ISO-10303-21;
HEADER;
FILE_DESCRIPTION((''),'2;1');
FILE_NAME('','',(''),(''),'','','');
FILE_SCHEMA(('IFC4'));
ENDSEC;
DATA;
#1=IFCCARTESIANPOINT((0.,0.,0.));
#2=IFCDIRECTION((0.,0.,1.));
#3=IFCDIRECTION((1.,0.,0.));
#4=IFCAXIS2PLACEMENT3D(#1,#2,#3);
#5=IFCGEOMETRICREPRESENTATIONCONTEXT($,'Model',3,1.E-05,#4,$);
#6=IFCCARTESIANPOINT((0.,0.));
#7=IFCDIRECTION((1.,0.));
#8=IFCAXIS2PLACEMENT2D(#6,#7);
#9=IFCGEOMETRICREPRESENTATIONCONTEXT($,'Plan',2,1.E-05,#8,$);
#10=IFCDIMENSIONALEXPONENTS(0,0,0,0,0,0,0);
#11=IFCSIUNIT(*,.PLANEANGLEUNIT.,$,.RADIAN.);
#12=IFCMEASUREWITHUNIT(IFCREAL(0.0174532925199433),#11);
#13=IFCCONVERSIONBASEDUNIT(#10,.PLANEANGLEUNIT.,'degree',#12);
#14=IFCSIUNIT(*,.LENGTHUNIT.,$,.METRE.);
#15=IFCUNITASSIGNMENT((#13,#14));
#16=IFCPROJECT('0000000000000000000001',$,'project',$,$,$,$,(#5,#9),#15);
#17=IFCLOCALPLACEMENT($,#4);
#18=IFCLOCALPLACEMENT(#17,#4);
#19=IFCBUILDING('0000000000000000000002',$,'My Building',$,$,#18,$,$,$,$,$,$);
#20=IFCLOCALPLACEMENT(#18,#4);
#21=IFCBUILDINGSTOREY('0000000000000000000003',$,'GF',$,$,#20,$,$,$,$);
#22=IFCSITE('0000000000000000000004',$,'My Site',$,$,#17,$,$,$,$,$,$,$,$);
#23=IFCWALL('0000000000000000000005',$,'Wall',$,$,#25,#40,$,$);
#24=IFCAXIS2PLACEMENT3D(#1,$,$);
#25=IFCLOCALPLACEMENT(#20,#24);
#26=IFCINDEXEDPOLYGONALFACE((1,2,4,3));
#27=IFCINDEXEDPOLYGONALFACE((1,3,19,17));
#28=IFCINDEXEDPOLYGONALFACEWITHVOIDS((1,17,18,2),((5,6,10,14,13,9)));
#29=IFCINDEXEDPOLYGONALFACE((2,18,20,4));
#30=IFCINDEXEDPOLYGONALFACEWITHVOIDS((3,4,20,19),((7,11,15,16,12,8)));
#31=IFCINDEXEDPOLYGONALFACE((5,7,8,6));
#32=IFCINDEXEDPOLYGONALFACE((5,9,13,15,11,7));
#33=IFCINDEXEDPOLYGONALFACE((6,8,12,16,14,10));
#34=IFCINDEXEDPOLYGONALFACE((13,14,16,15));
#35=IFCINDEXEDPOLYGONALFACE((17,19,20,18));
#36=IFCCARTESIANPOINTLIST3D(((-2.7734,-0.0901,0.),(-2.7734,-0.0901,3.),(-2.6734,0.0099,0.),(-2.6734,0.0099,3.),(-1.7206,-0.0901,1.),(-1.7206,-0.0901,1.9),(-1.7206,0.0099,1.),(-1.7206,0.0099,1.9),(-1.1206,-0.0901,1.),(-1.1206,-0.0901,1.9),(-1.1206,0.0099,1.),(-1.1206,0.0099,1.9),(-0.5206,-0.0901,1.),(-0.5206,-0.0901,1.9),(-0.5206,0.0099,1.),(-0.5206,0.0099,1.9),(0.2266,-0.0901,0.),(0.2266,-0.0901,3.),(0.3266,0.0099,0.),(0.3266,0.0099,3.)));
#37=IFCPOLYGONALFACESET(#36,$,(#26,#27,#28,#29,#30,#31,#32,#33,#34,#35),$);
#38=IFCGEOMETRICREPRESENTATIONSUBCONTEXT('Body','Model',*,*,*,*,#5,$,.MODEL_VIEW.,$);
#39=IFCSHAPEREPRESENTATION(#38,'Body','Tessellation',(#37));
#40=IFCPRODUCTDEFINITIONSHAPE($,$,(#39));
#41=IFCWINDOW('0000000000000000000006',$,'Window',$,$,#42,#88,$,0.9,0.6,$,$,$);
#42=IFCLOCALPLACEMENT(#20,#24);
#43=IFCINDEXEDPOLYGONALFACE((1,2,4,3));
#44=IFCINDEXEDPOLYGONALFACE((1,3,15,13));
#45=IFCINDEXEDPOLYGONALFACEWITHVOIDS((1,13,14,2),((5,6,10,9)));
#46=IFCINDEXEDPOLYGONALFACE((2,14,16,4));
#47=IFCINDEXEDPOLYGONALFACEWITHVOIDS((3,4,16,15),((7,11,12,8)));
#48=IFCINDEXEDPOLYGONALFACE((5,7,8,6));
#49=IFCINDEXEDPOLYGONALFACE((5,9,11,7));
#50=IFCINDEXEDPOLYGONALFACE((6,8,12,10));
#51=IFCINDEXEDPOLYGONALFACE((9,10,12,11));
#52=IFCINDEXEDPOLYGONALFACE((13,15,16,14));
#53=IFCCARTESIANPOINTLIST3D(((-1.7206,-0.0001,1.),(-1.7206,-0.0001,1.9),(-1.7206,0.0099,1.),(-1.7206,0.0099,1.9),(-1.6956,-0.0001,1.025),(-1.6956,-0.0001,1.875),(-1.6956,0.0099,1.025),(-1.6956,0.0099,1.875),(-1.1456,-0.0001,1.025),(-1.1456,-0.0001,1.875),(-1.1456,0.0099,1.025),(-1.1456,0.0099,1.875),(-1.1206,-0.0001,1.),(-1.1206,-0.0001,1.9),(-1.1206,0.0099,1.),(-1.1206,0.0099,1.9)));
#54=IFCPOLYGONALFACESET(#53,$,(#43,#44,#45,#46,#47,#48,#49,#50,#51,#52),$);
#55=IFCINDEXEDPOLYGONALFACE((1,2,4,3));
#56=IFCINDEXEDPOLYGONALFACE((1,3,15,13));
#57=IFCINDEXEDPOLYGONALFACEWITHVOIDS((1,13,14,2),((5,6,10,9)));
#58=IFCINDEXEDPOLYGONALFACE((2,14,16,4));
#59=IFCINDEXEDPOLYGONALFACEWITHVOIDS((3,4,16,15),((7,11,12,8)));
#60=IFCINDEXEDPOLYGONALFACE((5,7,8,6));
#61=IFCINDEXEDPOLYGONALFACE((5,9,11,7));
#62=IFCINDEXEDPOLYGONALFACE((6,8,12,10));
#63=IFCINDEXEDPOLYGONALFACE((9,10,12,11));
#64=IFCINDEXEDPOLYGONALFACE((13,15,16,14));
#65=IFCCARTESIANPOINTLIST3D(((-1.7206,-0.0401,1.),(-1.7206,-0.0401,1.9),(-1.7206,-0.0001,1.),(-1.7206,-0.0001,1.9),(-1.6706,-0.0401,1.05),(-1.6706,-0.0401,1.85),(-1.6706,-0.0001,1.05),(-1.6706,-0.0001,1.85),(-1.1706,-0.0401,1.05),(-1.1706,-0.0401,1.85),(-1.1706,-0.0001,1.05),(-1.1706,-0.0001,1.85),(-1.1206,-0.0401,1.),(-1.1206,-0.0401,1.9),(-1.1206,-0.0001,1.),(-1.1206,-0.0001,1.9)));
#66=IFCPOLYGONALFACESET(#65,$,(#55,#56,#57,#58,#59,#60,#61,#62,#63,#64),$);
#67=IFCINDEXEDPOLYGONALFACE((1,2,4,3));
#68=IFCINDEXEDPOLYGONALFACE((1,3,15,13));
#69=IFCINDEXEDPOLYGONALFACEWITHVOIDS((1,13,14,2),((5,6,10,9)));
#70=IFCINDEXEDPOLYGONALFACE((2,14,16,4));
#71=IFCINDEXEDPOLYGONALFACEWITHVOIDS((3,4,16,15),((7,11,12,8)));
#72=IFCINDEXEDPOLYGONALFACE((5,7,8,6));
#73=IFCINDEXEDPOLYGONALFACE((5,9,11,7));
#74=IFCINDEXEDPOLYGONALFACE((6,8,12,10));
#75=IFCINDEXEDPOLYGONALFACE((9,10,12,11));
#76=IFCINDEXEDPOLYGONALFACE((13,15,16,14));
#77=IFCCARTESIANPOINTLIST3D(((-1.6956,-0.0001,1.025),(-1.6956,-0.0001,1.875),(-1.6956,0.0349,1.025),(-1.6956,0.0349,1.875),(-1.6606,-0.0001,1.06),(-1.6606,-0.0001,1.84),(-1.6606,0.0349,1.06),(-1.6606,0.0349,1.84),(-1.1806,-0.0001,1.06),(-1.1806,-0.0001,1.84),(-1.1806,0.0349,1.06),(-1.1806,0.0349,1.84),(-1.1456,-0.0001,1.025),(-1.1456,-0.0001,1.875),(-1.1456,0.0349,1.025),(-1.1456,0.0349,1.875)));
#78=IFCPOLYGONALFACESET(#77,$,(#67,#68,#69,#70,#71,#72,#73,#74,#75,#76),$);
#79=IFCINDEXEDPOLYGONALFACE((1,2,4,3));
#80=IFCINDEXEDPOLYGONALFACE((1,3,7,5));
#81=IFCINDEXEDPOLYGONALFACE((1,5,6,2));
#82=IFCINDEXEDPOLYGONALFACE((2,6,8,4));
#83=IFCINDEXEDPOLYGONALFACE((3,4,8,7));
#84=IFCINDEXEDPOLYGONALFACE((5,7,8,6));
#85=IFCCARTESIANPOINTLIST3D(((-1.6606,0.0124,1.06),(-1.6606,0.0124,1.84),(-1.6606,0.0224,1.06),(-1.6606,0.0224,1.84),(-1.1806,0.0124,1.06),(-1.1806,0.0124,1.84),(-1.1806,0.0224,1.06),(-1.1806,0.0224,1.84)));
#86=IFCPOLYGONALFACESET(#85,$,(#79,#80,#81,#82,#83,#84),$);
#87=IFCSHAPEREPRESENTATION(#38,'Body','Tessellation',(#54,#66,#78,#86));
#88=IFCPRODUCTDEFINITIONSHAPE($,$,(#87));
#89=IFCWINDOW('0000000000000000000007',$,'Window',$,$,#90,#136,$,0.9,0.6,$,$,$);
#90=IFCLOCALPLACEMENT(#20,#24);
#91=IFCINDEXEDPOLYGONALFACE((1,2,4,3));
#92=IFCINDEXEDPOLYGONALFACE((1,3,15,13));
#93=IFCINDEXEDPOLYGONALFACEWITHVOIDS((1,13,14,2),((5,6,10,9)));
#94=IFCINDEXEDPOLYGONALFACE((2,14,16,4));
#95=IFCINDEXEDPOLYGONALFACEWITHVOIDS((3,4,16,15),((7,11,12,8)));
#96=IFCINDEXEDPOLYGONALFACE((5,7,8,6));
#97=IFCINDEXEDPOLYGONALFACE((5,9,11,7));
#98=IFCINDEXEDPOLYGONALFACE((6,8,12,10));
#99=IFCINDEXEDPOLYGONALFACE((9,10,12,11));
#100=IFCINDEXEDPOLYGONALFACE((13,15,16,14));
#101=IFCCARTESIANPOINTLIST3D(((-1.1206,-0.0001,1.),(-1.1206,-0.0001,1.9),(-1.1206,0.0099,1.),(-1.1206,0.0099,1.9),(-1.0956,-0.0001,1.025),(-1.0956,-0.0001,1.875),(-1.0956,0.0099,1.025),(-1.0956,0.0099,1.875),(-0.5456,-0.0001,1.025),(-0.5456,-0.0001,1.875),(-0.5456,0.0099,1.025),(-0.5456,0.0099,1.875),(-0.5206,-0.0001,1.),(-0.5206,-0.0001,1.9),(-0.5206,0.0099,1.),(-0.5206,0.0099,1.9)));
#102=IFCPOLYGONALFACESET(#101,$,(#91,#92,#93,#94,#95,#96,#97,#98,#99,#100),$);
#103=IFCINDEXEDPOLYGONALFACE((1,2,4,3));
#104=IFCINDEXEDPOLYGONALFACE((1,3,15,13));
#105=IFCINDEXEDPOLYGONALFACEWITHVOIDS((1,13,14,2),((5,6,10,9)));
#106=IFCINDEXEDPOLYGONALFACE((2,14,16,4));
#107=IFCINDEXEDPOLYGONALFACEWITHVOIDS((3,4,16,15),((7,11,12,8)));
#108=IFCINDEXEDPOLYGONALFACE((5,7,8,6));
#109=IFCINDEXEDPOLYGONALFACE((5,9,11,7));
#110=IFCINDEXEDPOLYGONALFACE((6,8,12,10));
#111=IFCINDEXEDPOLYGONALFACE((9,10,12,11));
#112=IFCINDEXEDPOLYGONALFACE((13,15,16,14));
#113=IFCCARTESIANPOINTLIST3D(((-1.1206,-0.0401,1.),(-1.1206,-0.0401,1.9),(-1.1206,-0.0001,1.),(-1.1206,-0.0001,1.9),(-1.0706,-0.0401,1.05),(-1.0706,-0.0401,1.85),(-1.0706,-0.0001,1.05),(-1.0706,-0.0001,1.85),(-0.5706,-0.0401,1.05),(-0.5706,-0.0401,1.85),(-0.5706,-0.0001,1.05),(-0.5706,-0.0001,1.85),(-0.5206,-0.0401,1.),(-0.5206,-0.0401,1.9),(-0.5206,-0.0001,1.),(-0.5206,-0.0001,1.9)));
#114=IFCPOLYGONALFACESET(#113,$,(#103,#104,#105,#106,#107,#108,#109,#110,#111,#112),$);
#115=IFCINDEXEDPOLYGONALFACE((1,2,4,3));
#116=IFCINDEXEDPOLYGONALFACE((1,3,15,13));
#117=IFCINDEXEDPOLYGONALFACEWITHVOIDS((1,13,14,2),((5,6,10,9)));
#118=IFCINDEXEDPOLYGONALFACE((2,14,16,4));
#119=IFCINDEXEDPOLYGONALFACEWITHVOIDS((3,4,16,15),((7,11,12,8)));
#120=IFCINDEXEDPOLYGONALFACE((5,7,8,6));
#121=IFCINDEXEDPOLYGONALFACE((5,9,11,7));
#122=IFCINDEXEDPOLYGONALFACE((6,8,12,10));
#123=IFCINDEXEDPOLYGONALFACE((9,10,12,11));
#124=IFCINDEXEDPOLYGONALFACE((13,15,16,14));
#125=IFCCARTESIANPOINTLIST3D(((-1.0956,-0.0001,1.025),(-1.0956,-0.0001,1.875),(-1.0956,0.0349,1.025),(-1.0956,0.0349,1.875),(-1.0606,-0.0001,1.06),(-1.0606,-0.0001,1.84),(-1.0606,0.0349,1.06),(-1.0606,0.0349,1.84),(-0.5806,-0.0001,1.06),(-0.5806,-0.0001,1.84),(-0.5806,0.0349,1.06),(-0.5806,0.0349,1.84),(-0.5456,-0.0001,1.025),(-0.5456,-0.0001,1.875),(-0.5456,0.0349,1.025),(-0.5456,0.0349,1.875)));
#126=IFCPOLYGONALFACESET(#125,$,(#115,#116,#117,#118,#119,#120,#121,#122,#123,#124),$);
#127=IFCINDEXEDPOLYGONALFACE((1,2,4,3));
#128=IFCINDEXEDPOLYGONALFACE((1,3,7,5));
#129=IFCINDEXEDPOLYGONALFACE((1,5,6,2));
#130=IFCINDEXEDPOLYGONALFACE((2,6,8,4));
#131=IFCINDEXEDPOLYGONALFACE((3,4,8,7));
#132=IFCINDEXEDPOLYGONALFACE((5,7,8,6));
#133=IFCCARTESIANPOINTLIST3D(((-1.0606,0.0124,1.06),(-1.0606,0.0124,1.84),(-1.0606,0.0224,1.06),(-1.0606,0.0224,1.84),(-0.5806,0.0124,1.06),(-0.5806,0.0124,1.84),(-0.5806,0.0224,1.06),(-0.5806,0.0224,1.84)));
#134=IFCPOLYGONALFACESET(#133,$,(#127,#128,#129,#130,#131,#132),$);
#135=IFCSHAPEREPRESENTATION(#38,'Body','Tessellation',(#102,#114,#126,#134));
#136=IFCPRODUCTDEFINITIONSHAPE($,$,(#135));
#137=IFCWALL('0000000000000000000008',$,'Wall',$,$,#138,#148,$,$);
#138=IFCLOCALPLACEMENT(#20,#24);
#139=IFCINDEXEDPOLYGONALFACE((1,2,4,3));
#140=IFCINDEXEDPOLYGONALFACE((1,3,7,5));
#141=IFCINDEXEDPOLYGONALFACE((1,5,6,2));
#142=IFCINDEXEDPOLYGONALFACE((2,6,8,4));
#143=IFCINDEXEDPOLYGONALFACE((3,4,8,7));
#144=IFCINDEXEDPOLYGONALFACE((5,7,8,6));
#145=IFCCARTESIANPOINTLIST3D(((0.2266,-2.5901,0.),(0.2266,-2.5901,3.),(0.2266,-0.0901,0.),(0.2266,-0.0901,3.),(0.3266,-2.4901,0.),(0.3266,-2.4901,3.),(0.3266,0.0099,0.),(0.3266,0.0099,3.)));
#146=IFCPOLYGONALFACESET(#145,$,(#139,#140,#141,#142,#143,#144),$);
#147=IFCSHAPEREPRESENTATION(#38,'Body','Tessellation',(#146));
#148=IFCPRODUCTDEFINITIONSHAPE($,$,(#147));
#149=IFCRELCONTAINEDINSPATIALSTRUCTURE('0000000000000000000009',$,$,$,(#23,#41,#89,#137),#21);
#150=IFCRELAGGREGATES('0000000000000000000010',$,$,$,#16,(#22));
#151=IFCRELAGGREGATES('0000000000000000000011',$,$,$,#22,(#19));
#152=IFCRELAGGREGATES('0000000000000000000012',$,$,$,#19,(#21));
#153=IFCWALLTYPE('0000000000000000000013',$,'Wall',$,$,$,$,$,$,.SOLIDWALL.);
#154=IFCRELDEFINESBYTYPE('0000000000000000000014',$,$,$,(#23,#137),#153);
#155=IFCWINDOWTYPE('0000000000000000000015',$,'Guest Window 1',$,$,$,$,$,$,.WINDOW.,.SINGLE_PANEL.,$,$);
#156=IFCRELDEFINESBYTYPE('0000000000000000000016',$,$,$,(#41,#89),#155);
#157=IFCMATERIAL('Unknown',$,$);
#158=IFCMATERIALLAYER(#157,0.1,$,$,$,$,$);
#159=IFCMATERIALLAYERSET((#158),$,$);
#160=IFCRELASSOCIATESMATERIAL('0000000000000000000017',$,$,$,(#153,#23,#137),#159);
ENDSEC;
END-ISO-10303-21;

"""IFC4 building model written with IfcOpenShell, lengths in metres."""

from ifc_helpers import new_model, entity, si_unit, converted_unit, frame, origin_with_axes, origin_2d_with_axis, place, context, subcontext, project, spatial, line, indexed_curve, outline, extrude, shape, source, transform, mapped, material, layer, layer_set, layer_usage, type_object, type_shapes, element, fill, save


model = new_model("IFC4")

# Units and contexts
model_context = context("Model", 3, precision=1e-05, world=origin_with_axes())
plan_context = context("Plan", 2, precision=1e-05, world=origin_2d_with_axis())
body_context_1 = subcontext(model_context, "Body", "Model", "MODEL_VIEW")
body_context_2 = subcontext(plan_context, "Body", "Plan", "PLAN_VIEW")
ifc_project = project(units=[converted_unit("PLANEANGLEUNIT", "degree", entity("IfcReal", 0.0174532925199433), si_unit("PLANEANGLEUNIT", "RADIAN"), dimensions=[0, 0, 0, 0, 0, 0, 0]), si_unit("LENGTHUNIT", "METRE")], contexts=[model_context, plan_context])

# Site, building, storey
site_placement = place(None, origin_with_axes())
site = spatial("IfcSite", under=ifc_project, at=site_placement, Name="My Site")
building_placement = place(site_placement, origin_with_axes())
building = spatial("IfcBuilding", under=site, at=building_placement, Name="My Building")
storey_placement = place(building_placement, origin_with_axes())
storey = spatial("IfcBuildingStorey", under=building, at=storey_placement, Name="GF")

# Shared definitions
ifc_material = material(Name="Unknown")

# Shared definitions
ifc_layer_1 = layer(ifc_material, 0.1)
ifc_layer_set_1 = layer_set([ifc_layer_1])
wall_type = type_object("IfcWallType", Name="Wall", PredefinedType="SOLIDWALL", material=ifc_layer_set_1)

# Wall, openings, windows
ifc_layer_usage_1 = layer_usage(ifc_layer_set_1, "AXIS2", "POSITIVE", 0.0)
wall_1_placement = place(storey_placement, frame((-2.7734, -0.0901, 0.0), z_axis=(0.0, 0.0, 1.0), x_axis=(1.0, 0.0, 0.0)))
wall_1 = element("IfcWall", 1, at=wall_1_placement, inside=storey, type_object=wall_type, material=ifc_layer_usage_1, Name="Wall", context=body_context_1, shape_type="SweptSolid", body=[
    extrude(outline(indexed_curve([(0.0, 0.0), (0.1, 0.1), (3.1, 0.1), (3.0, 0.0)], segments=[line(1, 2, 3, 4, 1)])), origin_with_axes(), (0.0, 0.0, 1.0), 3.0),
])
shared_shape_1 = source(origin_with_axes(), body_context_1, "Body", "SweptSolid", [
    extrude(outline(indexed_curve([(0.0, 0.0), (0.6, 0.0), (0.6, 0.9), (0.0, 0.9)], segments=[line(1, 2, 3, 4, 1)])), frame((0.0, -0.6, 0.0), z_axis=(0.0, -1.0, 0.0), x_axis=(1.0, 0.0, 0.0)), (0.0, 0.0, -1.0), 1.2),
])
opening_1_placement = place(wall_1_placement, frame((1.0528, 0.0, 1.0), z_axis=(0.0, 0.0, 1.0), x_axis=(1.0, 0.0, 0.0)))
opening_1 = element("IfcOpeningElement", 2, at=opening_1_placement, cuts=wall_1, PredefinedType="OPENING", context=body_context_1, shape_type="MappedRepresentation", body=[
    mapped(shared_shape_1, transform((0.0, 0.0, 0.0), x_axis=(1.0, 0.0, 0.0), y_axis=(0.0, 1.0, 0.0), z_axis=(0.0, 0.0, 1.0), scale=1.0)),
])
opening_2_placement = place(wall_1_placement, frame((1.6528, 0.0, 1.0), z_axis=(0.0, 0.0, 1.0), x_axis=(1.0, 0.0, 0.0)))
opening_2 = element("IfcOpeningElement", 3, at=opening_2_placement, cuts=wall_1, PredefinedType="OPENING", context=body_context_1, shape_type="MappedRepresentation", body=[
    mapped(shared_shape_1, transform((0.0, 0.0, 0.0), x_axis=(1.0, 0.0, 0.0), y_axis=(0.0, 1.0, 0.0), z_axis=(0.0, 0.0, 1.0), scale=1.0)),
])
window_type_1 = type_object("IfcWindowType", Name="Guest Window 1", PartitioningType="SINGLE_PANEL", PredefinedType="WINDOW")
shared_shape_2 = source(origin_with_axes(), body_context_1, "Body", "SweptSolid", [
    extrude(outline(indexed_curve([(0.0, 0.0), (0.6, 0.0), (0.6, 0.9), (0.0, 0.9)], segments=[line(1, 2, 3, 4, 1)]), holes=[indexed_curve([(0.025, 0.025), (0.575, 0.025), (0.575, 0.875), (0.025, 0.875)], segments=[line(1, 2, 3, 4, 1)])]), frame((0.0, 0.09, 0.0), z_axis=(0.0, -1.0, 0.0), x_axis=(1.0, 0.0, 0.0)), (0.0, 0.0, -1.0), 0.01),
    extrude(outline(indexed_curve([(0.0, 0.0), (0.6, 0.0), (0.6, 0.9), (0.0, 0.9)], segments=[line(1, 2, 3, 4, 1)]), holes=[indexed_curve([(0.05, 0.05), (0.55, 0.05), (0.55, 0.85), (0.05, 0.85)], segments=[line(1, 2, 3, 4, 1)])]), frame((0.0, 0.05, 0.0), z_axis=(0.0, -1.0, 0.0), x_axis=(1.0, 0.0, 0.0)), (0.0, 0.0, -1.0), 0.04),
    extrude(outline(indexed_curve([(0.0, 0.0), (0.55, 0.0), (0.55, 0.85), (0.0, 0.85)], segments=[line(1, 2, 3, 4, 1)]), holes=[indexed_curve([(0.035, 0.035), (0.515, 0.035), (0.515, 0.815), (0.035, 0.815)], segments=[line(1, 2, 3, 4, 1)])]), frame((0.025, 0.09, 0.025), z_axis=(0.0, -1.0, 0.0), x_axis=(1.0, 0.0, 0.0)), (0.0, 0.0, -1.0), 0.035),
    extrude(outline(indexed_curve([(0.035, 0.035), (0.515, 0.035), (0.515, 0.815), (0.035, 0.815)], segments=[line(1, 2, 3, 4, 1)])), frame((0.025, 0.1025, 0.025), z_axis=(0.0, -1.0, 0.0), x_axis=(1.0, 0.0, 0.0)), (0.0, 0.0, -1.0), 0.01),
])
shared_shape_3 = source(origin_with_axes(), body_context_2, "Body", "Curve2D", [
    entity("IfcIndexedPolyCurve", entity("IfcCartesianPointList2D", [[0.05, 0.05], [0.55, 0.05]])),
    entity("IfcIndexedPolyCurve", entity("IfcCartesianPointList2D", [[0.0, 0.1], [0.025, 0.1], [0.025, 0.09], [0.05, 0.09], [0.05, 0.05], [0.0, 0.05]]), [entity("IfcLineIndex", [1, 2, 3, 4, 5, 6, 1])]),
    entity("IfcIndexedPolyCurve", entity("IfcCartesianPointList2D", [[0.6, 0.1], [0.575, 0.1], [0.575, 0.09], [0.55, 0.09], [0.55, 0.05], [0.6, 0.05]]), [entity("IfcLineIndex", [1, 2, 3, 4, 5, 6, 1])]),
    entity("IfcIndexedPolyCurve", entity("IfcCartesianPointList2D", [[0.025, 0.09], [0.06, 0.09], [0.06, 0.125], [0.025, 0.125]]), [entity("IfcLineIndex", [1, 2, 3, 4, 1])]),
    entity("IfcIndexedPolyCurve", entity("IfcCartesianPointList2D", [[0.575, 0.09], [0.54, 0.09], [0.54, 0.125], [0.575, 0.125]]), [entity("IfcLineIndex", [1, 2, 3, 4, 1])]),
    entity("IfcIndexedPolyCurve", entity("IfcCartesianPointList2D", [[0.06, 0.09], [0.54, 0.09]])),
    entity("IfcIndexedPolyCurve", entity("IfcCartesianPointList2D", [[0.06, 0.125], [0.54, 0.125]])),
    entity("IfcIndexedPolyCurve", entity("IfcCartesianPointList2D", [[0.06, 0.1075], [0.54, 0.1075]])),
])
type_shapes(window_type_1, [shared_shape_2, shared_shape_3])
window_1_placement = place(opening_1_placement, origin_with_axes())
window_1 = element("IfcWindow", 4, at=window_1_placement, inside=storey, type_object=window_type_1, Name="Window", OverallHeight=0.9, OverallWidth=0.6, shapes=[
    shape(body_context_1, "Body", "MappedRepresentation", [mapped(shared_shape_2, transform((0.0, 0.0, 0.0), x_axis=(1.0, 0.0, 0.0), y_axis=(0.0, 1.0, 0.0), z_axis=(0.0, 0.0, 1.0), scale=1.0))]),
    shape(body_context_2, "Body", "MappedRepresentation", [mapped(shared_shape_3, transform((0.0, 0.0, 0.0), x_axis=(1.0, 0.0, 0.0), y_axis=(0.0, 1.0, 0.0), z_axis=(0.0, 0.0, 1.0), scale=1.0))]),
])
fill(opening_1, window_1)
window_2_placement = place(opening_2_placement, origin_with_axes())
window_2 = element("IfcWindow", 5, at=window_2_placement, inside=storey, type_object=window_type_1, Name="Window", OverallHeight=0.9, OverallWidth=0.6, shapes=[
    shape(body_context_1, "Body", "MappedRepresentation", [mapped(shared_shape_2, transform((0.0, 0.0, 0.0), x_axis=(1.0, 0.0, 0.0), y_axis=(0.0, 1.0, 0.0), z_axis=(0.0, 0.0, 1.0), scale=1.0))]),
    shape(body_context_2, "Body", "MappedRepresentation", [mapped(shared_shape_3, transform((0.0, 0.0, 0.0), x_axis=(1.0, 0.0, 0.0), y_axis=(0.0, 1.0, 0.0), z_axis=(0.0, 0.0, 1.0), scale=1.0))]),
])
fill(opening_2, window_2)

# Wall
ifc_layer_usage_2 = layer_usage(ifc_layer_set_1, "AXIS2", "POSITIVE", 0.0)
wall_2_placement = place(storey_placement, frame((0.2266, -0.0901, 0.0), z_axis=(0.0, 0.0, 1.0), x_axis=(0.0, -1.0, 0.0)))
element("IfcWall", 6, at=wall_2_placement, inside=storey, type_object=wall_type, material=ifc_layer_usage_2, Name="Wall", context=body_context_1, shape_type="SweptSolid", body=[
    extrude(outline(indexed_curve([(0.0, 0.0), (-0.1, 0.1), (2.4, 0.1), (2.5, 0.0)], segments=[line(1, 2, 3, 4, 1)])), origin_with_axes(), (0.0, 0.0, 1.0), 3.0),
])

save(model, "model.ifc")
